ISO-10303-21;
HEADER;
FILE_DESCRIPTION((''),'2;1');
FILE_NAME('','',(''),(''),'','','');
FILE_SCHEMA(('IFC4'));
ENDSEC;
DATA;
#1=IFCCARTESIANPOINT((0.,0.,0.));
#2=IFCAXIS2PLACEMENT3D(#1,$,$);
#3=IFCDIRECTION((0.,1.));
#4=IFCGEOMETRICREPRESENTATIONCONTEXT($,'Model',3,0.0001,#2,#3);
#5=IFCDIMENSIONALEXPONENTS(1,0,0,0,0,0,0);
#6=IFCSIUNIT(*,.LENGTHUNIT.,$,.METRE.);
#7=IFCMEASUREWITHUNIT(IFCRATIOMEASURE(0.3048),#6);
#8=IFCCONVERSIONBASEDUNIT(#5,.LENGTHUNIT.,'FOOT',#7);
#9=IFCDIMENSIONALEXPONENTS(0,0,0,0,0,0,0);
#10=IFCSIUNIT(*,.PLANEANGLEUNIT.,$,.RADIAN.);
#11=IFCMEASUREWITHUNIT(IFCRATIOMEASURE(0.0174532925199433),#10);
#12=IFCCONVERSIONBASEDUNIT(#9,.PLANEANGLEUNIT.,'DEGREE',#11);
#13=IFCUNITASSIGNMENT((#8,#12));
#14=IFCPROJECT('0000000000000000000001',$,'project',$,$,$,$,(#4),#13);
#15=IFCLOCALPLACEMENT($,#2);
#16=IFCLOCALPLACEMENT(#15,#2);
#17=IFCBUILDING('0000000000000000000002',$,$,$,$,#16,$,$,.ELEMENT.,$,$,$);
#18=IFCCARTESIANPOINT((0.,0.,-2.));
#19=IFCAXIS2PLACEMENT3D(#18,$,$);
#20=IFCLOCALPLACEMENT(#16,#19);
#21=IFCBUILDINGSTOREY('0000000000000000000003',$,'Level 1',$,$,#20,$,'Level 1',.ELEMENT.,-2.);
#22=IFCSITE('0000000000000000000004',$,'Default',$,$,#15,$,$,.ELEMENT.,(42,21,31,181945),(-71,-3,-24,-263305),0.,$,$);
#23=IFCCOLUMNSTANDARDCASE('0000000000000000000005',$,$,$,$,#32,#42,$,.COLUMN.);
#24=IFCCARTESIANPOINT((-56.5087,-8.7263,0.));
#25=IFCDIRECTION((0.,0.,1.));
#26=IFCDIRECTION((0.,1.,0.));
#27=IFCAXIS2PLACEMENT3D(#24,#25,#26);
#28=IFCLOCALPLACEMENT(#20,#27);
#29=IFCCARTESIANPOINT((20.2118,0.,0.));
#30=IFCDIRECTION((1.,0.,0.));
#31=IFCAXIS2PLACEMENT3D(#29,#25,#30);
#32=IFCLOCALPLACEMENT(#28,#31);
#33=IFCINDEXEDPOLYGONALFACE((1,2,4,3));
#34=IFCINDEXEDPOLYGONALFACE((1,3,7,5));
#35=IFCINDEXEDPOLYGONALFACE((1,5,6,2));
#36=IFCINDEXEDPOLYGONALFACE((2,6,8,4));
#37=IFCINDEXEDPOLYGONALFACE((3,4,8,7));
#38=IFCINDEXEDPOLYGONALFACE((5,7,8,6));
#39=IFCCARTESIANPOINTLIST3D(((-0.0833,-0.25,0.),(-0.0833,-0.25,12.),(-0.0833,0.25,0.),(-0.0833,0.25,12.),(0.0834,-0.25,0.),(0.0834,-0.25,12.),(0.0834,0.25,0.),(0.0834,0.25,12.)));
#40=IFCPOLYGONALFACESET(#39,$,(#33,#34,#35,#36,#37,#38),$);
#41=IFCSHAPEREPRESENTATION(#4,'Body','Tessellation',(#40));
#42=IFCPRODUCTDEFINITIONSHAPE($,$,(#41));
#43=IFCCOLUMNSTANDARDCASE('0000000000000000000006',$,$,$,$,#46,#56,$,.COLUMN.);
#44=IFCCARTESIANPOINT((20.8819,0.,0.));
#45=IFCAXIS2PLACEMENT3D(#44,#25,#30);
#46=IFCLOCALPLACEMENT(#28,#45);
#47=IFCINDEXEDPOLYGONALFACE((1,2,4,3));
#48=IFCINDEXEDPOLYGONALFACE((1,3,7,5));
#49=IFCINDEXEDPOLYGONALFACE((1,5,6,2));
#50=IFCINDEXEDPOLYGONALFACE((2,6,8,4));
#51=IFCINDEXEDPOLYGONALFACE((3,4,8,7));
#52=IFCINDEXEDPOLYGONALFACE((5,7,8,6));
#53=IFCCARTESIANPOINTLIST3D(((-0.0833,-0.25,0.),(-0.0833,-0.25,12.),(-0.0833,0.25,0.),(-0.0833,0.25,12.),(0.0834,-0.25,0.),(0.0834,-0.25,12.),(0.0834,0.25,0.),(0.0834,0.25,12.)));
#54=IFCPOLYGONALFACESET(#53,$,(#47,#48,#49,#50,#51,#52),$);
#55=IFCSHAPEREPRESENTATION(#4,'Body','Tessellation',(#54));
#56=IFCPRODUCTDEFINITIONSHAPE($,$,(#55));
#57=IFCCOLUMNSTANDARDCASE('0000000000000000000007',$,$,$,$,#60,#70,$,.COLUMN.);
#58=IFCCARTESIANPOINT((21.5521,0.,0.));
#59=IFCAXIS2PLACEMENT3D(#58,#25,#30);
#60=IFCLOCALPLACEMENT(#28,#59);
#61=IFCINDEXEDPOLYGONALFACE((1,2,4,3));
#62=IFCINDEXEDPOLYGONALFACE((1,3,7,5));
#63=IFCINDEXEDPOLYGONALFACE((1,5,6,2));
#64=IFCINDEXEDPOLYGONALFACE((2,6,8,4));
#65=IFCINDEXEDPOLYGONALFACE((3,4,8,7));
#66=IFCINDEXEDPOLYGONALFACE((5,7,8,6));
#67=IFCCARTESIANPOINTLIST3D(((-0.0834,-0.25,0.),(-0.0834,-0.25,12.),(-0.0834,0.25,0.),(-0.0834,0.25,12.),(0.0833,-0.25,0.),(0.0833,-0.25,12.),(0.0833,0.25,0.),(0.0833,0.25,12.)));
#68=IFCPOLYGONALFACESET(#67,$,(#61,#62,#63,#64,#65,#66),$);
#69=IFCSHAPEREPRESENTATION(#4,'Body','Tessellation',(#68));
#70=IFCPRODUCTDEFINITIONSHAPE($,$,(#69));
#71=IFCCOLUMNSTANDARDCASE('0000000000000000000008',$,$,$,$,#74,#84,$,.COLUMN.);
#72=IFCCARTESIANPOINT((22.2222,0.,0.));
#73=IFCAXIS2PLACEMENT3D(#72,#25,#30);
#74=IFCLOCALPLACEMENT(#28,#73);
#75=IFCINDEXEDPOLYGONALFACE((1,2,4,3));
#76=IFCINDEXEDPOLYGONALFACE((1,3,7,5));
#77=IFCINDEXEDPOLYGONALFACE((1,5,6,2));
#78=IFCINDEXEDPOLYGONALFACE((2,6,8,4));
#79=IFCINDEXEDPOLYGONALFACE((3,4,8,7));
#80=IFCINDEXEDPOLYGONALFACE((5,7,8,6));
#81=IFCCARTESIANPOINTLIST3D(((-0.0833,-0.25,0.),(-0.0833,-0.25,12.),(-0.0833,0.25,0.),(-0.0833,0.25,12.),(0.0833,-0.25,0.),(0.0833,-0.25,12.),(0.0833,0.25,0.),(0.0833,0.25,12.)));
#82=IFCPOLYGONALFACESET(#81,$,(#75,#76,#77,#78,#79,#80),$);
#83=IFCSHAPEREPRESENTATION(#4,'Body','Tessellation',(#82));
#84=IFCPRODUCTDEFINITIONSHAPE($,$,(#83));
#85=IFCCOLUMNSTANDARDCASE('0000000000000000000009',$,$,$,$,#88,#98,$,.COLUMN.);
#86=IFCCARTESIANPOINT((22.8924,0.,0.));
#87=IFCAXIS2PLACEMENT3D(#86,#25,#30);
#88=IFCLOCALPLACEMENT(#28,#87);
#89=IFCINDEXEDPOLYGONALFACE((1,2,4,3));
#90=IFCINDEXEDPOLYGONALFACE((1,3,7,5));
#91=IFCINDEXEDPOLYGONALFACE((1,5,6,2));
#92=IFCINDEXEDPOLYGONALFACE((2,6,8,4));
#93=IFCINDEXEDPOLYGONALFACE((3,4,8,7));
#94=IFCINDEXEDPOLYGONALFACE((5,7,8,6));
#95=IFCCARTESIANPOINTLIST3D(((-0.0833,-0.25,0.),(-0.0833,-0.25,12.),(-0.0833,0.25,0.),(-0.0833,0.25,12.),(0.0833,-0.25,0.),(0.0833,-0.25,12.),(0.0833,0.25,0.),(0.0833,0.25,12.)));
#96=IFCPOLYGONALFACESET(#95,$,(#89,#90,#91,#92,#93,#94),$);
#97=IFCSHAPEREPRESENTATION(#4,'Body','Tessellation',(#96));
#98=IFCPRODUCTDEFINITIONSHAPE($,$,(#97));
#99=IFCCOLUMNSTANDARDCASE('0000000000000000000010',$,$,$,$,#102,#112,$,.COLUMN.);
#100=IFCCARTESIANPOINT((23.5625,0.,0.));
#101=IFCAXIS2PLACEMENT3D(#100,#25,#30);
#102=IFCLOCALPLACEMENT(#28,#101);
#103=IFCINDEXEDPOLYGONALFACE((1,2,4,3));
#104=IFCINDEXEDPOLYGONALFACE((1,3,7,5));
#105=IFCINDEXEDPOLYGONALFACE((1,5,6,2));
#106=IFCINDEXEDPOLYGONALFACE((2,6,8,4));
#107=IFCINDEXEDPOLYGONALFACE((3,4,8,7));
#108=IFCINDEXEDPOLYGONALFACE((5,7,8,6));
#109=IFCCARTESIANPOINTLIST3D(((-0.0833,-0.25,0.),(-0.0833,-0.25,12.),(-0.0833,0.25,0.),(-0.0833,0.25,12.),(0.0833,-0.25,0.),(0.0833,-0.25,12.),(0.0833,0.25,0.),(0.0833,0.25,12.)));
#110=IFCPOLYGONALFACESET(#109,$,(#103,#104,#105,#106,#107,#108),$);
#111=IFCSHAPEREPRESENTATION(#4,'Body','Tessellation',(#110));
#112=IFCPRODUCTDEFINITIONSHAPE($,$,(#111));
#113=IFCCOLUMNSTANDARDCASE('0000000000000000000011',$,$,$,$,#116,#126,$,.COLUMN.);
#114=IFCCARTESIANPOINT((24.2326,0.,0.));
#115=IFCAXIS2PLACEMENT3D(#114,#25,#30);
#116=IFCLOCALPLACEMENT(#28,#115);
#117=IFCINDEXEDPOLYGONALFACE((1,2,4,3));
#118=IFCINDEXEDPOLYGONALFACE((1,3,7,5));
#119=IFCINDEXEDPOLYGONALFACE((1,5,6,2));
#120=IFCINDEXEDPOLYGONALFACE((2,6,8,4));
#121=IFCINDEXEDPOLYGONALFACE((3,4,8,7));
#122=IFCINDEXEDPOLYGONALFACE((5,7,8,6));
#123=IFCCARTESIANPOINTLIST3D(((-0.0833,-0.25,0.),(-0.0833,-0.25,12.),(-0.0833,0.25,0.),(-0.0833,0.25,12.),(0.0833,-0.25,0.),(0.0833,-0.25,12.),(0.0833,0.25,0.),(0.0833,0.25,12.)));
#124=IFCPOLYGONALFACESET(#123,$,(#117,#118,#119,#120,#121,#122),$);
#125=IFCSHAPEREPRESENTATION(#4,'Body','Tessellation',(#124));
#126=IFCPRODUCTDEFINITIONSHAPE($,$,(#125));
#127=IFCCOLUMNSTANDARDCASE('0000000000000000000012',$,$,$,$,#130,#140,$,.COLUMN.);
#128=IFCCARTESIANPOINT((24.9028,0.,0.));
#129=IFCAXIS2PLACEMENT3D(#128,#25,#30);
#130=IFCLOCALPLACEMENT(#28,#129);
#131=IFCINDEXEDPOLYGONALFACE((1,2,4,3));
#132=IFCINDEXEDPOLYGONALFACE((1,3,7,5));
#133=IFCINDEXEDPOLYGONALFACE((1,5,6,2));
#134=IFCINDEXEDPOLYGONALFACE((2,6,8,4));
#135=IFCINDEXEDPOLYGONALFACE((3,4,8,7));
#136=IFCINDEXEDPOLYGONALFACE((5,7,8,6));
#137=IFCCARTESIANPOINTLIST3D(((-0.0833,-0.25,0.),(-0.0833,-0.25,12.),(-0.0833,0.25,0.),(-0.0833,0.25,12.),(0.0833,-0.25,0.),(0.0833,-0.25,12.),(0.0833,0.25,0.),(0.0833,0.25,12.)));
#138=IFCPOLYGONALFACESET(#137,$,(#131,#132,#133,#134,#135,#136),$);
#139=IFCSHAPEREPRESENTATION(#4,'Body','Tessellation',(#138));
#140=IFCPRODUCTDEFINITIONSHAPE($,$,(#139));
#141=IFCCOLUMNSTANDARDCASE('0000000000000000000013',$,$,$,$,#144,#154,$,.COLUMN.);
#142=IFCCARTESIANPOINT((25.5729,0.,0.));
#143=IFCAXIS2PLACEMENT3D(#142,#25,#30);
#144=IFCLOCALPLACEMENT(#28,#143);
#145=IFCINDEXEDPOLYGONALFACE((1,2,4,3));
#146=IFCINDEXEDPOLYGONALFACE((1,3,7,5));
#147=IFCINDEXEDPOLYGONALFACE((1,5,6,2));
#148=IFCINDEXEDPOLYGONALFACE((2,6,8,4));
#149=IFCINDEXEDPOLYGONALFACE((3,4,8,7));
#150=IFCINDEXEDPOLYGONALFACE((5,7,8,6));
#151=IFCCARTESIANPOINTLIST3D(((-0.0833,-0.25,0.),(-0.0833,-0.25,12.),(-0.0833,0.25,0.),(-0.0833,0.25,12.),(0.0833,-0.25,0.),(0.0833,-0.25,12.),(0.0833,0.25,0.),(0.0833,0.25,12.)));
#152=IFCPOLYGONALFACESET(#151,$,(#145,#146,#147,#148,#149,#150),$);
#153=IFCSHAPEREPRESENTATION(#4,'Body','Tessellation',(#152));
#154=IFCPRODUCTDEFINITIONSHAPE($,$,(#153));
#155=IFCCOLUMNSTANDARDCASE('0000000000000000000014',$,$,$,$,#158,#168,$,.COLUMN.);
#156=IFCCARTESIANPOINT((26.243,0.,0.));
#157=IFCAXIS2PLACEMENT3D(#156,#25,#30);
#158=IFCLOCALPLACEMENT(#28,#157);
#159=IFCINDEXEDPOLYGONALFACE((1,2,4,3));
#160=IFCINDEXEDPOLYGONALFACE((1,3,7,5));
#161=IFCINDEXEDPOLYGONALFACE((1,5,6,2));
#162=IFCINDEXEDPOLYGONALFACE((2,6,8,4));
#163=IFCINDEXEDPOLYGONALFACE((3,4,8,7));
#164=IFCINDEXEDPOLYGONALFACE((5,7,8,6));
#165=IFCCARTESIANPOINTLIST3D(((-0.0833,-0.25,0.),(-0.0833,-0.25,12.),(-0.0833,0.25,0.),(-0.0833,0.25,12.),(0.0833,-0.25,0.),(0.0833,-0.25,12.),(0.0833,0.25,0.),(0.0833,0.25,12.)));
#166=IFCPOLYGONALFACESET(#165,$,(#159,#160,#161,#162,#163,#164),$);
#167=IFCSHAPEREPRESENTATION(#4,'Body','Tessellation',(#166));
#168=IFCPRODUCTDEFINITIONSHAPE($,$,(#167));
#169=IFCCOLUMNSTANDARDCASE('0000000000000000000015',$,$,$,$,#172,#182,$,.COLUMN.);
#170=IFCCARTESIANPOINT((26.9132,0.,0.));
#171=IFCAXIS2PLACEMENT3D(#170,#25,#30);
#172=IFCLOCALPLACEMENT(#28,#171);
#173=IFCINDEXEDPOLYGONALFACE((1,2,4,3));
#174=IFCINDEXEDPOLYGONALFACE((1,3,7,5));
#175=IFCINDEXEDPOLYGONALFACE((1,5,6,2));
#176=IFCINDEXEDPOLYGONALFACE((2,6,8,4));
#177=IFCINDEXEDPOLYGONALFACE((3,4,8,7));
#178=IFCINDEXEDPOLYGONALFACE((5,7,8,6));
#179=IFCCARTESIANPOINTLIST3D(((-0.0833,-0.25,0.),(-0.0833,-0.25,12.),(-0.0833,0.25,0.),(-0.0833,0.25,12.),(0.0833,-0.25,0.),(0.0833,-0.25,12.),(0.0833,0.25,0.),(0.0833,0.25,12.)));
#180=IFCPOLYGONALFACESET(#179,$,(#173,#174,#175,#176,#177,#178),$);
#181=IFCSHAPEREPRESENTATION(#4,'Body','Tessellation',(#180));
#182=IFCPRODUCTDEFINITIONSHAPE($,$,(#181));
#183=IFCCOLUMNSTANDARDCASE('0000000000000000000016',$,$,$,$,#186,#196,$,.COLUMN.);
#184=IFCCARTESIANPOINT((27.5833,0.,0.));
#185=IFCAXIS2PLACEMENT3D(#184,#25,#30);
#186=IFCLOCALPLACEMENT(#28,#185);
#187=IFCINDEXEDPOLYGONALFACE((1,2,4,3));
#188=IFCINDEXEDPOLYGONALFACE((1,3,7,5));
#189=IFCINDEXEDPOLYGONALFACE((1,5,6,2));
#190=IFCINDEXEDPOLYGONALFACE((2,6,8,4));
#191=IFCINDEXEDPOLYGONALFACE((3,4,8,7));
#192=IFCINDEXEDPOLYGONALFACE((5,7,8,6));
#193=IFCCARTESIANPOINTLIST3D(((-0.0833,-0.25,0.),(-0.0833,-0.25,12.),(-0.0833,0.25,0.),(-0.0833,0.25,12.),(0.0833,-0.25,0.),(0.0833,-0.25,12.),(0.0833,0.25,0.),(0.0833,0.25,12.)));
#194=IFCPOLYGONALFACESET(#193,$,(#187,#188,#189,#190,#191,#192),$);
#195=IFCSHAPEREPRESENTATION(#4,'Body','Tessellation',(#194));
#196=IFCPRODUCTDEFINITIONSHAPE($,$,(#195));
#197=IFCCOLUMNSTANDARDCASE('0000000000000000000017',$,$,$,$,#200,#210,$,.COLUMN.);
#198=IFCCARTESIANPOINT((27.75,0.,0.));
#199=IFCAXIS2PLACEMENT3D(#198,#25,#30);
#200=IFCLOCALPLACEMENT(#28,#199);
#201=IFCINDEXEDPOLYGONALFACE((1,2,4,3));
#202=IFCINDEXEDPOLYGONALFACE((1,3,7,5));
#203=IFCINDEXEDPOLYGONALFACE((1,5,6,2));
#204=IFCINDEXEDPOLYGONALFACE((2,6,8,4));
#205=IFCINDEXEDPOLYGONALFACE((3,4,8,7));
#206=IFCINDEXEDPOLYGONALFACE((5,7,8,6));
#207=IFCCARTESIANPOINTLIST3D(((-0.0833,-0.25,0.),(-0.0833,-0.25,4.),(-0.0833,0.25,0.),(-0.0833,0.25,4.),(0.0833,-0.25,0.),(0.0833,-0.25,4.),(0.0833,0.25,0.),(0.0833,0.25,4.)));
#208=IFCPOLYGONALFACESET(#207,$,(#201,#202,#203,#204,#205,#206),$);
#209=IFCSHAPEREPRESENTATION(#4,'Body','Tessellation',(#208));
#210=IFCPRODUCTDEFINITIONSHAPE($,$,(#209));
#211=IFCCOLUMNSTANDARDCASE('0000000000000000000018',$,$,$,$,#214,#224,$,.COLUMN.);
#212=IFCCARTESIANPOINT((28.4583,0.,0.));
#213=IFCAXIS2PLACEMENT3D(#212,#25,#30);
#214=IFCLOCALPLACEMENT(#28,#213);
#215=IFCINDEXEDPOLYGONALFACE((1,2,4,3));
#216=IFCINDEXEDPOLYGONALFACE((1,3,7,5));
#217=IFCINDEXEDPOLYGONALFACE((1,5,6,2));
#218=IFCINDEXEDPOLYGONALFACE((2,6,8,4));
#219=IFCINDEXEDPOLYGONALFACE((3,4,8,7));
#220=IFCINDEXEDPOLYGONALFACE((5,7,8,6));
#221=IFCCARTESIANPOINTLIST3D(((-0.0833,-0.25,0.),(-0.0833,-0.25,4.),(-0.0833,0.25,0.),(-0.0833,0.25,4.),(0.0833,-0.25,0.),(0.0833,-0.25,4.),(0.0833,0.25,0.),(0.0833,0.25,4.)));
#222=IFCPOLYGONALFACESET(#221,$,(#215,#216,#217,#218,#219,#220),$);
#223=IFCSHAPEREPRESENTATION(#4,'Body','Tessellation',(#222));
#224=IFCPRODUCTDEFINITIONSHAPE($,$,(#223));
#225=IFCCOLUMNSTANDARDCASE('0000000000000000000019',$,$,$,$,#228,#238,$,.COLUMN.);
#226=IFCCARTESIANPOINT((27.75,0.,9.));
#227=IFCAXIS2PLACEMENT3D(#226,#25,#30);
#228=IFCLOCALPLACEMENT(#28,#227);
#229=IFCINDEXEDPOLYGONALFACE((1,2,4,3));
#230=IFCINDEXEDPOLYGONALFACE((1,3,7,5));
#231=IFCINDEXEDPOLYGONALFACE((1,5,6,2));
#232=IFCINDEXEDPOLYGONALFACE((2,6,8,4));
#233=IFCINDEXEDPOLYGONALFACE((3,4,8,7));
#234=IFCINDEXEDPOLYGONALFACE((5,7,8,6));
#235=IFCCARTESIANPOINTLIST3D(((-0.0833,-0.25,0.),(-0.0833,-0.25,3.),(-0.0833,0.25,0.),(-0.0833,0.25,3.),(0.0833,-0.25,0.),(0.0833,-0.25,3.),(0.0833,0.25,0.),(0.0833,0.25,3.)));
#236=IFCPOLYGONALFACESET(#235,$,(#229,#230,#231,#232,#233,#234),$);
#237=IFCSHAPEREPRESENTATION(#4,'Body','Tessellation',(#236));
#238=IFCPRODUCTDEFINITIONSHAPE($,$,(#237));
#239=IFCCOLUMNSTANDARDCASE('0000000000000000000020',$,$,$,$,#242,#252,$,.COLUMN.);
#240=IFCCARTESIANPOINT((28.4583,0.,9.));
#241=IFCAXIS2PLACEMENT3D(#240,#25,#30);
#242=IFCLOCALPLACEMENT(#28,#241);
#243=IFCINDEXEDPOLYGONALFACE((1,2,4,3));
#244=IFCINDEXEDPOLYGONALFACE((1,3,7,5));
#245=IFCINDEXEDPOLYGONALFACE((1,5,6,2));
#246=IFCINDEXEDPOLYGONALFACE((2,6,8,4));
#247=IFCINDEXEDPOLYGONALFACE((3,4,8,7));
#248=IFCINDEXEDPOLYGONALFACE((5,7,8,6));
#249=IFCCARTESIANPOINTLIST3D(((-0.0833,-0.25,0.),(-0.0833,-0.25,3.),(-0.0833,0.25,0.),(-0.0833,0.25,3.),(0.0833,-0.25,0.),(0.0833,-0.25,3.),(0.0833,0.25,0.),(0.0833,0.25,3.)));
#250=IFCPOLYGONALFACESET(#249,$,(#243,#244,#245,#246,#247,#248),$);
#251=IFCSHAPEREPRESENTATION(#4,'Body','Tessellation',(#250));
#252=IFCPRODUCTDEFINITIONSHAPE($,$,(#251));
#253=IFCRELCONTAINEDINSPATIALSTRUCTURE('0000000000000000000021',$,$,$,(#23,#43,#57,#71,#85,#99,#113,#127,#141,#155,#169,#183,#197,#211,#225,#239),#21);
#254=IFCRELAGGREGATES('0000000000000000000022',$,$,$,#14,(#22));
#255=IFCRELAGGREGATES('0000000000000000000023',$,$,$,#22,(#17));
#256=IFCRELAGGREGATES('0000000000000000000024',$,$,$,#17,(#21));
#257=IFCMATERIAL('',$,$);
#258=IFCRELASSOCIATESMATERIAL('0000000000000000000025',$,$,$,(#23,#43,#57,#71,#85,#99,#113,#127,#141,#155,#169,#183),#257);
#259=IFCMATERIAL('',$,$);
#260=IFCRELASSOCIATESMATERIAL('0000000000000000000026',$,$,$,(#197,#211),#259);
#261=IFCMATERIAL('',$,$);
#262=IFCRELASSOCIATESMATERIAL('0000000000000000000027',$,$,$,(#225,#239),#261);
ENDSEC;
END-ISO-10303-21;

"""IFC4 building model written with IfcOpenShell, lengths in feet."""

from ifc_helpers import new_model, entity, si_unit, converted_unit, direction, frame, origin, place, context, project, spatial, rectangle, extrude, material, element, save


model = new_model("IFC4")

# Units and contexts
model_context = context("Model", 3, precision=0.0001, world=origin(), true_north=direction((0.0, 1.0)))
ifc_project = project(units=[converted_unit("LENGTHUNIT", "FOOT", entity("IfcRatioMeasure", 0.3048), si_unit("LENGTHUNIT", "METRE"), dimensions=[1, 0, 0, 0, 0, 0, 0]), converted_unit("PLANEANGLEUNIT", "DEGREE", entity("IfcRatioMeasure", 0.0174532925199433), si_unit("PLANEANGLEUNIT", "RADIAN"), dimensions=[0, 0, 0, 0, 0, 0, 0])], contexts=[model_context])

# Site, building, storey
site_placement = place(None, origin())
site = spatial("IfcSite", under=ifc_project, at=site_placement, Name="Default", CompositionType="ELEMENT", RefLatitude=(42, 21, 31, 181945), RefLongitude=(-71, -3, -24, -263305), RefElevation=0.0)
building_placement = place(site_placement, origin())
building = spatial("IfcBuilding", under=site, at=building_placement, CompositionType="ELEMENT")
storey_placement = place(building_placement, frame((0.0, 0.0, -2.0)))
storey = spatial("IfcBuildingStorey", under=building, at=storey_placement, Name="Level 1", LongName="Level 1", CompositionType="ELEMENT", Elevation=-2.0)

# Columns
ifc_material_1 = material(Name="")
placement = place(storey_placement, frame((-56.5087, -8.7263, 0.0), z_axis=(0.0, 0.0, 1.0), x_axis=(0.0, 1.0, 0.0)))
for number, where, z_axis, x_axis in (
    (1, (20.2118, 0.0, 0.0), (0.0, 0.0, 1.0), (1.0, 0.0, 0.0)),
    (2, (20.8819, 0.0, 0.0), (0.0, 0.0, 1.0), (1.0, 0.0, 0.0)),
    (3, (21.5521, 0.0, 0.0), (0.0, 0.0, 1.0), (1.0, 0.0, 0.0)),
    (4, (22.2222, 0.0, 0.0), (0.0, 0.0, 1.0), (1.0, 0.0, 0.0)),
    (5, (22.8924, 0.0, 0.0), (0.0, 0.0, 1.0), (1.0, 0.0, 0.0)),
    (6, (23.5625, 0.0, 0.0), (0.0, 0.0, 1.0), (1.0, 0.0, 0.0)),
    (7, (24.2326, 0.0, 0.0), (0.0, 0.0, 1.0), (1.0, 0.0, 0.0)),
    (8, (24.9028, 0.0, 0.0), (0.0, 0.0, 1.0), (1.0, 0.0, 0.0)),
    (9, (25.5729, 0.0, 0.0), (0.0, 0.0, 1.0), (1.0, 0.0, 0.0)),
    (10, (26.243, 0.0, 0.0), (0.0, 0.0, 1.0), (1.0, 0.0, 0.0)),
    (11, (26.9132, 0.0, 0.0), (0.0, 0.0, 1.0), (1.0, 0.0, 0.0)),
    (12, (27.5833, 0.0, 0.0), (0.0, 0.0, 1.0), (1.0, 0.0, 0.0)),
):
    element("IfcColumnStandardCase", number, at=place(placement, frame(where, z_axis=z_axis, x_axis=x_axis)), inside=storey, material=ifc_material_1, PredefinedType="COLUMN", context=model_context, shape_type="SweptSolid", body=[
        extrude(rectangle(XDim=0.1667, YDim=0.5), origin(), (0.0, 0.0, 1.0), 12.0),
    ])
ifc_material_2 = material(Name="")
for number, where, z_axis, x_axis in (
    (13, (27.75, 0.0, 0.0), (0.0, 0.0, 1.0), (1.0, 0.0, 0.0)),
    (14, (28.4583, 0.0, 0.0), (0.0, 0.0, 1.0), (1.0, 0.0, 0.0)),
):
    element("IfcColumnStandardCase", number, at=place(placement, frame(where, z_axis=z_axis, x_axis=x_axis)), inside=storey, material=ifc_material_2, PredefinedType="COLUMN", context=model_context, shape_type="SweptSolid", body=[
        extrude(rectangle(XDim=0.1667, YDim=0.5), origin(), (0.0, 0.0, 1.0), 4.0),
    ])
ifc_material_3 = material(Name="")
for number, where, z_axis, x_axis in (
    (15, (27.75, 0.0, 9.0), (0.0, 0.0, 1.0), (1.0, 0.0, 0.0)),
    (16, (28.4583, 0.0, 9.0), (0.0, 0.0, 1.0), (1.0, 0.0, 0.0)),
):
    element("IfcColumnStandardCase", number, at=place(placement, frame(where, z_axis=z_axis, x_axis=x_axis)), inside=storey, material=ifc_material_3, PredefinedType="COLUMN", context=model_context, shape_type="SweptSolid", body=[
        extrude(rectangle(XDim=0.1667, YDim=0.5), origin(), (0.0, 0.0, 1.0), 3.0),
    ])

save(model, "model.ifc")
